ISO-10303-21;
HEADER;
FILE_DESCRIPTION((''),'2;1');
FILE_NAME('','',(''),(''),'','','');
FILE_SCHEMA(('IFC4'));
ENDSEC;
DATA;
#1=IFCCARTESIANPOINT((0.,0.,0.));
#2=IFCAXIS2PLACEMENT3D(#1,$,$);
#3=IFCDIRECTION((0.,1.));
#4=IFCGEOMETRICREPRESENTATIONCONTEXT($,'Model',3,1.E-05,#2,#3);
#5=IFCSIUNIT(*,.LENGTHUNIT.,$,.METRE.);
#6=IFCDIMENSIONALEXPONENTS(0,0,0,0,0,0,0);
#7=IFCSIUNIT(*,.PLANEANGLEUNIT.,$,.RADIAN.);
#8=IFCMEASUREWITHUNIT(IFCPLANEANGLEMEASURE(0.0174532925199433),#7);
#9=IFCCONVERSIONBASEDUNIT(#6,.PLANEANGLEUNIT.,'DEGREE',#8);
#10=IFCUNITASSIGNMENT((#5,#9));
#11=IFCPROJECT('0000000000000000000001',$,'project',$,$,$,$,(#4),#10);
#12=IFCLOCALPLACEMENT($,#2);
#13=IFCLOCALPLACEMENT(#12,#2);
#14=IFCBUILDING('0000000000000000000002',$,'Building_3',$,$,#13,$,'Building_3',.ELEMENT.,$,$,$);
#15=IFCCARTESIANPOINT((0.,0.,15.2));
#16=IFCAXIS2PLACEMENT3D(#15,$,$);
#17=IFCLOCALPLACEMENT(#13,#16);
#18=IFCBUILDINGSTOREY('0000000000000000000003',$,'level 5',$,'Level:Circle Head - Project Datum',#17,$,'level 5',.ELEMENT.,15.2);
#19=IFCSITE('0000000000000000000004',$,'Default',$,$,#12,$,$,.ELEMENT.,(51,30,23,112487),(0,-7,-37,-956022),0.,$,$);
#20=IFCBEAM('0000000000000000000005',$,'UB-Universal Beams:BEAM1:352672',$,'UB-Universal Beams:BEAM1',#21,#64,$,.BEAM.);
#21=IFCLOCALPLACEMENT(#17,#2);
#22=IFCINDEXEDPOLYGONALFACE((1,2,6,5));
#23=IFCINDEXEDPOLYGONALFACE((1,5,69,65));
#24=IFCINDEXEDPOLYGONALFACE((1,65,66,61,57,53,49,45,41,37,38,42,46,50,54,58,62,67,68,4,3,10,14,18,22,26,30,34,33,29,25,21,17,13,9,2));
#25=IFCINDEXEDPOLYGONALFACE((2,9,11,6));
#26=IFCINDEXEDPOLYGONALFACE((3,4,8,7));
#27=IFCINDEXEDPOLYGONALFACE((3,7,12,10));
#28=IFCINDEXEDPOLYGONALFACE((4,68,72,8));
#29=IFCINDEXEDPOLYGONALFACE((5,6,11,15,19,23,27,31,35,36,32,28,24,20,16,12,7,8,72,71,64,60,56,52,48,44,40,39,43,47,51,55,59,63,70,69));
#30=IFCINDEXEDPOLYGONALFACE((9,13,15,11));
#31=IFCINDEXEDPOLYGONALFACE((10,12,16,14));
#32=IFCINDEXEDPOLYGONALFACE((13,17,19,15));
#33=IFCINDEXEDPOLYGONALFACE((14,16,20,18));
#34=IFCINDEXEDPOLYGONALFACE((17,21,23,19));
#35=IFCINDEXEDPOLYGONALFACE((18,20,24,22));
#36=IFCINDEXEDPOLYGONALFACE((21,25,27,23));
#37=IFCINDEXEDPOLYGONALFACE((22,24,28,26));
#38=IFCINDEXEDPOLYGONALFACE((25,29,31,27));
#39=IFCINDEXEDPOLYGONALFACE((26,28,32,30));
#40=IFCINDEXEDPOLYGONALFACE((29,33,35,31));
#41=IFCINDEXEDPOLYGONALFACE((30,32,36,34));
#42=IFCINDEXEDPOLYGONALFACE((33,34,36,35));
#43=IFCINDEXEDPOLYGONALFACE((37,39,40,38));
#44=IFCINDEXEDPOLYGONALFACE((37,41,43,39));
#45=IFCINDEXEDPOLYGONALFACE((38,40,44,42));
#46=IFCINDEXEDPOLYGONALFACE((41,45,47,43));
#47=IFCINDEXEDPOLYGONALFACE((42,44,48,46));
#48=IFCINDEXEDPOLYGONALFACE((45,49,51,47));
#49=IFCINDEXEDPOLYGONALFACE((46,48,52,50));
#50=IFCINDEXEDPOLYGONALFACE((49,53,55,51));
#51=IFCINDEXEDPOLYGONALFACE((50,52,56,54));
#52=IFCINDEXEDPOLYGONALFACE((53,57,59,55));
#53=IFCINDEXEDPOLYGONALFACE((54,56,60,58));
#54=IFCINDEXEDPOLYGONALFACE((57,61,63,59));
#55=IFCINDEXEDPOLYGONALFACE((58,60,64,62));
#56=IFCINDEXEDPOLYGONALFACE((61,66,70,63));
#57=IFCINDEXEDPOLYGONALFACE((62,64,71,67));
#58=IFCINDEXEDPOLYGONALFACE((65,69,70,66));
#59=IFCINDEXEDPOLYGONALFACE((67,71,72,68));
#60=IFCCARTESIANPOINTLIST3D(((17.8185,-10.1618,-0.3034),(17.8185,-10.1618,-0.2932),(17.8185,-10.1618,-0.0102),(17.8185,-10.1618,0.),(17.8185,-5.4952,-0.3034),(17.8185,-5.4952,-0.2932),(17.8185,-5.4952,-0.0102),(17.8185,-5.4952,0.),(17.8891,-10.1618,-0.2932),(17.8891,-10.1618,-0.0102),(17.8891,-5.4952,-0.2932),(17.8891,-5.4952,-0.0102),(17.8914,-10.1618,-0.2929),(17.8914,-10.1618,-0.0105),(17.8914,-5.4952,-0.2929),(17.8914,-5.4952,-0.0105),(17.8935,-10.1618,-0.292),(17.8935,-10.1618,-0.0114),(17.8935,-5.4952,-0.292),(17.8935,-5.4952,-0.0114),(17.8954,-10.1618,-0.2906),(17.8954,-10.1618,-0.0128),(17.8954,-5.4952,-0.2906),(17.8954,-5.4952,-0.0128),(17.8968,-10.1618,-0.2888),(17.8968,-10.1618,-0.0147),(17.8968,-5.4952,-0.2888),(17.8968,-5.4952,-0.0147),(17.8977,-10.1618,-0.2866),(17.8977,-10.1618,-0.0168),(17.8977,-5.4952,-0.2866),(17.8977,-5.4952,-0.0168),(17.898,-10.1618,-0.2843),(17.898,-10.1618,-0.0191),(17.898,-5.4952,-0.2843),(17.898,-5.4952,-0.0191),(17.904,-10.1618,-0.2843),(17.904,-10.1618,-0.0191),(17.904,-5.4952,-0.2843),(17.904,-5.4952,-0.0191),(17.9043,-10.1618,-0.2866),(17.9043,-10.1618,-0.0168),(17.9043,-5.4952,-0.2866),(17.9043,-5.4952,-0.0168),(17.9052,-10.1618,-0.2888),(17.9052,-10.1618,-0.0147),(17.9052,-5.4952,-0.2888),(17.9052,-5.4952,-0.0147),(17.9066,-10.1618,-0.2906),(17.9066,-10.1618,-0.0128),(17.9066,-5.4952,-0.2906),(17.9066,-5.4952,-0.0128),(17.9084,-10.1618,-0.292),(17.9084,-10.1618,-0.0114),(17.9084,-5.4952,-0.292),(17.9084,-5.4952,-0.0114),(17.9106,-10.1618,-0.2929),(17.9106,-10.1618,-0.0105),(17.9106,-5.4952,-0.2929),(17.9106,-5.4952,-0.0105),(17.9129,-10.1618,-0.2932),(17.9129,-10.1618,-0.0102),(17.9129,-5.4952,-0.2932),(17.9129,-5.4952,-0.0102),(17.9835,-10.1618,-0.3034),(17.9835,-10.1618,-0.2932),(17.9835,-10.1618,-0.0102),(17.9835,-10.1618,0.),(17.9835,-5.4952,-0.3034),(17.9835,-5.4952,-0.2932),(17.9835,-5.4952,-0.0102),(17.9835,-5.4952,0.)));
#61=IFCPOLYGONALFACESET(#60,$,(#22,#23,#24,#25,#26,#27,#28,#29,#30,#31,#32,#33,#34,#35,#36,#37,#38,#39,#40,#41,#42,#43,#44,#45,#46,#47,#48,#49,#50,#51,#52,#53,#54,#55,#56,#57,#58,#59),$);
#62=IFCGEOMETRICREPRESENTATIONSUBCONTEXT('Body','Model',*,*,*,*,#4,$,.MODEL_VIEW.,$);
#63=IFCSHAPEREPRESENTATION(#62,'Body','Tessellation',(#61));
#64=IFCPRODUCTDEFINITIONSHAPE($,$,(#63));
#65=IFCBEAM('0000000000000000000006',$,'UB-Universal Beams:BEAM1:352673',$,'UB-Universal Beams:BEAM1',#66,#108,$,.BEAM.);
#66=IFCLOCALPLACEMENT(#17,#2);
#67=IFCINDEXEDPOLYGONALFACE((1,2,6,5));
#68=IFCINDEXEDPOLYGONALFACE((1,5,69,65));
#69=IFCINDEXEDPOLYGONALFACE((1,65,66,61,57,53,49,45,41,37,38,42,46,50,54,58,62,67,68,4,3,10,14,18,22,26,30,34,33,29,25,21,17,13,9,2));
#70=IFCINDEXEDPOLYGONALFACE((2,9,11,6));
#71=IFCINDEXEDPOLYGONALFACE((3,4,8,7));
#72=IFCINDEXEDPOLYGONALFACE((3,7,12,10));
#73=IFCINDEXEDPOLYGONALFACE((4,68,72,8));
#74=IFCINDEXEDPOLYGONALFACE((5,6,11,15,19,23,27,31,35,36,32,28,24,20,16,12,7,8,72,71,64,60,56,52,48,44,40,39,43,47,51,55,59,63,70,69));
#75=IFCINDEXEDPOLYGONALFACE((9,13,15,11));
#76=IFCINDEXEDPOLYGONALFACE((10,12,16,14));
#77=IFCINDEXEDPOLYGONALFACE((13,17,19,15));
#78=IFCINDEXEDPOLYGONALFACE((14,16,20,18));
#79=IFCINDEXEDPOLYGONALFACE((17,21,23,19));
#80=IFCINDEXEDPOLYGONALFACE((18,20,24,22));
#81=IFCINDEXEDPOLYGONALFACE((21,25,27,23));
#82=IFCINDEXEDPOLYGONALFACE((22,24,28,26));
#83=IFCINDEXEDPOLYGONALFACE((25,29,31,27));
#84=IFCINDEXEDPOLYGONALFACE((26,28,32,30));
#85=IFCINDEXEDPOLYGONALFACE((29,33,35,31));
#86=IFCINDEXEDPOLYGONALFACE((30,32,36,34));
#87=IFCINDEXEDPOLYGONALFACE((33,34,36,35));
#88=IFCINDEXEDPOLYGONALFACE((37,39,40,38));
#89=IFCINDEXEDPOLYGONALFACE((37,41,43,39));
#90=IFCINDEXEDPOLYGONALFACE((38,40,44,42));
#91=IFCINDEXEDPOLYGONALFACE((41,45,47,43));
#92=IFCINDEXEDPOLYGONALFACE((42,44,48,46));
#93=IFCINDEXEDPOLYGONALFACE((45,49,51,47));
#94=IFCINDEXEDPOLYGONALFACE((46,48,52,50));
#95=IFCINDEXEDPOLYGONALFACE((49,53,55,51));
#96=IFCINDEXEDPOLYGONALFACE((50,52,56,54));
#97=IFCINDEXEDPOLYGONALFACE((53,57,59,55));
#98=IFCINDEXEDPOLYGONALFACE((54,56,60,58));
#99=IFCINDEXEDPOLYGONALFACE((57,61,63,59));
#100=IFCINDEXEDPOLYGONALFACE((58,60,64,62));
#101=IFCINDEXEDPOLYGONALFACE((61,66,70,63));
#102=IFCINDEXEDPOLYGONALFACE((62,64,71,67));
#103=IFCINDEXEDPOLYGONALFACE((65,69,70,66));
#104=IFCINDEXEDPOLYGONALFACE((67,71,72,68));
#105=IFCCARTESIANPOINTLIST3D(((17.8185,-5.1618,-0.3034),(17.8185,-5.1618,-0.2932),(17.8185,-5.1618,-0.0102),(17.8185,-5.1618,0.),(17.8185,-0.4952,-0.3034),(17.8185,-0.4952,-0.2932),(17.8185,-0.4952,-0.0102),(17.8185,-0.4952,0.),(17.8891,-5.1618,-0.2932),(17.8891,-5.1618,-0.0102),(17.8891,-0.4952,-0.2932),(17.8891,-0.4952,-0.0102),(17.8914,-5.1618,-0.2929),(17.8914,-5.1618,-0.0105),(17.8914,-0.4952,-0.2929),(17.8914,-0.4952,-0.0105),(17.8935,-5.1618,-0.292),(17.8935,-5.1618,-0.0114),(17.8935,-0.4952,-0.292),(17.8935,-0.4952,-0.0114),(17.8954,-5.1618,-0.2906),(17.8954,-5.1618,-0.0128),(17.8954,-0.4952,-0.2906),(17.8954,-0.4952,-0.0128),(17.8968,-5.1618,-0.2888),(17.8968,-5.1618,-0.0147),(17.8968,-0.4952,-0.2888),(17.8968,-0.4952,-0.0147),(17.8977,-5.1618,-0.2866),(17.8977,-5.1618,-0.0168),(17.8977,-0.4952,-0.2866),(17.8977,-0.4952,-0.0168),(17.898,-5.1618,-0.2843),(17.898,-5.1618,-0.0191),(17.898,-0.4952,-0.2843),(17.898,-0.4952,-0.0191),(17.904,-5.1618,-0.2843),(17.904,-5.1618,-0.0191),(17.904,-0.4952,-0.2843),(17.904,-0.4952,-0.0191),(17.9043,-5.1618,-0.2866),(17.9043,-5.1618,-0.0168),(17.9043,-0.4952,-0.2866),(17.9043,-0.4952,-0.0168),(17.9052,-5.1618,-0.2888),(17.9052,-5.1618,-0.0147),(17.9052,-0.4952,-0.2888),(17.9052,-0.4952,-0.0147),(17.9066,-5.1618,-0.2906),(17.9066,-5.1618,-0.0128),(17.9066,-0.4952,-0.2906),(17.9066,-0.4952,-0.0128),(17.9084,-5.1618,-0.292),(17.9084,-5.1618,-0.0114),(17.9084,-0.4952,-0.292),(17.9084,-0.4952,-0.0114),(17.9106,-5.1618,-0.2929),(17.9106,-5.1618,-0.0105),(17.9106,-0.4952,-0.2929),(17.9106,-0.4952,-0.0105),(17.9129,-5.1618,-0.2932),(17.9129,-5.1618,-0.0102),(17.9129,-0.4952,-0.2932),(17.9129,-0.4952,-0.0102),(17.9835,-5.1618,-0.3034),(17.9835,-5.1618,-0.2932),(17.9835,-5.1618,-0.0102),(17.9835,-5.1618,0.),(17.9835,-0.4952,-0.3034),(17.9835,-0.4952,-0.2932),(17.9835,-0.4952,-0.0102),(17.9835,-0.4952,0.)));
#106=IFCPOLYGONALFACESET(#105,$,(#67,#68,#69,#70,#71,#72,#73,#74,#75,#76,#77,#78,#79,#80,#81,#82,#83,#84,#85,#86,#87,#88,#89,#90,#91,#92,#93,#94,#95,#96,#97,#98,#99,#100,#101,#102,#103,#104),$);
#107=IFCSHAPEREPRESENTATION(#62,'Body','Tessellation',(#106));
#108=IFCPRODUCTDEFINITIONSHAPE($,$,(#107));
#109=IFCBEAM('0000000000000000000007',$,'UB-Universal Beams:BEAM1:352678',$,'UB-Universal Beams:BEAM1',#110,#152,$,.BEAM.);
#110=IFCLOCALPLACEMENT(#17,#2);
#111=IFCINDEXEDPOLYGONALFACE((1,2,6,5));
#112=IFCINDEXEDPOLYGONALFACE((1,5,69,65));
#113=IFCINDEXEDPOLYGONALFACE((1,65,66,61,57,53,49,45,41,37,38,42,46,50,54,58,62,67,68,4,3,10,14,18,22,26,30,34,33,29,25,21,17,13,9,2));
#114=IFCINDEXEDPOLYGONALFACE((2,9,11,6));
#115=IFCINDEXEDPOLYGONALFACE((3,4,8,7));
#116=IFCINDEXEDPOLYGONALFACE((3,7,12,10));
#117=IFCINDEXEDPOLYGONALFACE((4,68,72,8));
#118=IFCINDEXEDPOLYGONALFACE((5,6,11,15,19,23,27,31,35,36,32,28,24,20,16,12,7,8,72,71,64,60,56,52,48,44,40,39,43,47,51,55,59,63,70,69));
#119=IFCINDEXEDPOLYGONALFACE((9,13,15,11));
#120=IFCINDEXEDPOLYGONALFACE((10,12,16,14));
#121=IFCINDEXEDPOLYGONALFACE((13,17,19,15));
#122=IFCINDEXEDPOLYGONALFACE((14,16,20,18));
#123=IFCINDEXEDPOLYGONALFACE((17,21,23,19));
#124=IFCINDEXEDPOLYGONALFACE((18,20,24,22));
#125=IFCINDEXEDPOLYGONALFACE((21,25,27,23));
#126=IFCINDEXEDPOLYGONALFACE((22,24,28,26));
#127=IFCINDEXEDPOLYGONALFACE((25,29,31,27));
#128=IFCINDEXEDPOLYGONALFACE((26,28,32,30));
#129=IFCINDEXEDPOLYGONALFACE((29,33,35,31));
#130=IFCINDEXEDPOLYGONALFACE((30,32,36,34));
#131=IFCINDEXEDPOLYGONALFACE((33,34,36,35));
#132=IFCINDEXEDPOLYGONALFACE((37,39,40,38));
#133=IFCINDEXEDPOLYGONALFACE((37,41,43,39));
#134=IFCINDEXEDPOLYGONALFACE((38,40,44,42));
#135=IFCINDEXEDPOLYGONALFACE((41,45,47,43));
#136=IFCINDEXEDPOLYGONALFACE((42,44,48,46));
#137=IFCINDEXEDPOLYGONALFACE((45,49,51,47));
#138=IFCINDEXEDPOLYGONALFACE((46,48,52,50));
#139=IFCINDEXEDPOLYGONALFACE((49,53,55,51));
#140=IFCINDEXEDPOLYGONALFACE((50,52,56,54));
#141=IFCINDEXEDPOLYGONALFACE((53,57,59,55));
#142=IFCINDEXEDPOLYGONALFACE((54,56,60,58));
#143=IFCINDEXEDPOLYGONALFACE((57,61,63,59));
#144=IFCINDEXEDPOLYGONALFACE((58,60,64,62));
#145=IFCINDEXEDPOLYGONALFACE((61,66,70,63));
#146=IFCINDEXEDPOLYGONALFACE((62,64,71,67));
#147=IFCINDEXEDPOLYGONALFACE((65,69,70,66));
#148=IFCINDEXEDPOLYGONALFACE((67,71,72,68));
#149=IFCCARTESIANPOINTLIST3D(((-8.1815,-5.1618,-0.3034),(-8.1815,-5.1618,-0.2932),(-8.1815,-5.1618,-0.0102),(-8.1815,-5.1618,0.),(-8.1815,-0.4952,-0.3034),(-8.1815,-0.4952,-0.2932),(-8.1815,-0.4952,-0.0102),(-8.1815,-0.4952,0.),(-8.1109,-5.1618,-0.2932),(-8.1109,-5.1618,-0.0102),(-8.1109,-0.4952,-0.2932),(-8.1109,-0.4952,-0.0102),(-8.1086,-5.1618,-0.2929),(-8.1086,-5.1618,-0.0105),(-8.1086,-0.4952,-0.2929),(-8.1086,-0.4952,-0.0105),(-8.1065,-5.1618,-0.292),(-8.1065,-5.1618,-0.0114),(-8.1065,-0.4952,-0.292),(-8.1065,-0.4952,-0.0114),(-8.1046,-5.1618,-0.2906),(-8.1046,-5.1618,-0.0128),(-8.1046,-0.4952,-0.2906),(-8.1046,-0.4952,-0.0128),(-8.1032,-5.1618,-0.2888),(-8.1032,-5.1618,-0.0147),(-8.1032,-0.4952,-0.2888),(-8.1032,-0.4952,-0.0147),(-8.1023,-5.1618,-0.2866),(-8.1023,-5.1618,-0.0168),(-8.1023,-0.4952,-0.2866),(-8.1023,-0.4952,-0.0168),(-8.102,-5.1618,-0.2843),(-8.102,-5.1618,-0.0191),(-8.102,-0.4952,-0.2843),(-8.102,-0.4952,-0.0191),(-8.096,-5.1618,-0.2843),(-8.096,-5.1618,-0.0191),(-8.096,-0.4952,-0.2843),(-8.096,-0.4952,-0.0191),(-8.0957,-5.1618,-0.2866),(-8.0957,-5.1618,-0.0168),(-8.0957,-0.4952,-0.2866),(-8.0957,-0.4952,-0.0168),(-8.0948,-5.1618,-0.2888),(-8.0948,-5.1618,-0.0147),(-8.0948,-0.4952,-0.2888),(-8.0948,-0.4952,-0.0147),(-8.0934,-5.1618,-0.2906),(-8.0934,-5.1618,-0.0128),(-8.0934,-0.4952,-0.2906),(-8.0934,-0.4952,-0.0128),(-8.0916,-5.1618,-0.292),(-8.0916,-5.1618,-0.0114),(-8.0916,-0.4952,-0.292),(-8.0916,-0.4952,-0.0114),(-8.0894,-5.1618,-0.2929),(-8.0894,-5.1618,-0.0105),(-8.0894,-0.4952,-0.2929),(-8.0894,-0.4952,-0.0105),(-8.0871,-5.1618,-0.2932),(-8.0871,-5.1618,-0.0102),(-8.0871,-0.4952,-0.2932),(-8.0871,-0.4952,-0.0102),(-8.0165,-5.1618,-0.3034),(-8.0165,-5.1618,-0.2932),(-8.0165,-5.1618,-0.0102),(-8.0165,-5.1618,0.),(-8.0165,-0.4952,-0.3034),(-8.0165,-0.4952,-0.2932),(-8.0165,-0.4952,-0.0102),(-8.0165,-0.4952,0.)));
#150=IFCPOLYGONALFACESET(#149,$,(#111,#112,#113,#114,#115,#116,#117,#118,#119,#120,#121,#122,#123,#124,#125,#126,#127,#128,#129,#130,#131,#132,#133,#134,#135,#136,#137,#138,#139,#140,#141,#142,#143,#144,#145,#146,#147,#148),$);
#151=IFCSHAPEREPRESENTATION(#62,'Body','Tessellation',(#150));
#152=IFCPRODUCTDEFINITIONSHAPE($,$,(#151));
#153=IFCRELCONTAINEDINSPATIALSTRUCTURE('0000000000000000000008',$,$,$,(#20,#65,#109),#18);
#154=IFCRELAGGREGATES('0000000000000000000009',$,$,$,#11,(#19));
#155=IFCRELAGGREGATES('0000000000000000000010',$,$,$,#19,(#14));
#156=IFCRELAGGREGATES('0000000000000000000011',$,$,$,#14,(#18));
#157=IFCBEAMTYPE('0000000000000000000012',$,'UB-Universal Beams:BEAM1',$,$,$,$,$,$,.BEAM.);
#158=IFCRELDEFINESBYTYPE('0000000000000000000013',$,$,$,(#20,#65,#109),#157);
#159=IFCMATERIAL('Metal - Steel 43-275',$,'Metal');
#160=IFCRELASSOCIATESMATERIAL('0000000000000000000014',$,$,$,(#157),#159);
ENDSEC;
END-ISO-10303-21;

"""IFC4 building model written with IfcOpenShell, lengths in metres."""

from ifc_helpers import new_model, entity, si_unit, converted_unit, direction, frame, frame_2d, origin, place, context, subcontext, project, spatial, polyline, circle_curve, parameter, trimmed, segment, composite_curve, outline, extrude, source, transform, mapped, material, material_profile, profile_set, type_object, type_shapes, element, save


model = new_model("IFC4")

# Units and contexts
model_context = context("Model", 3, precision=1e-05, world=origin(), true_north=direction((0.0, 1.0)))
body_context = subcontext(model_context, "Body", "Model", "MODEL_VIEW")
ifc_project = project(units=[si_unit("LENGTHUNIT", "METRE"), converted_unit("PLANEANGLEUNIT", "DEGREE", entity("IfcPlaneAngleMeasure", 0.0174532925199433), si_unit("PLANEANGLEUNIT", "RADIAN"), dimensions=[0, 0, 0, 0, 0, 0, 0])], contexts=[model_context])

# Site, building, storey
site_placement = place(None, origin())
site = spatial("IfcSite", under=ifc_project, at=site_placement, Name="Default", CompositionType="ELEMENT", RefLatitude=(51, 30, 23, 112487), RefLongitude=(0, -7, -37, -956022), RefElevation=0.0)
building_placement = place(site_placement, origin())
building = spatial("IfcBuilding", under=site, at=building_placement, Name="Building_3", LongName="Building_3", CompositionType="ELEMENT")
storey_placement = place(building_placement, frame((0.0, 0.0, 15.2)))
storey = spatial("IfcBuildingStorey", under=building, at=storey_placement, Name="level 5", ObjectType="Level:Circle Head - Project Datum", LongName="level 5", CompositionType="ELEMENT", Elevation=15.2)

# Beams
ifc_material_1 = material(Name="Metal - Steel 43-275", Category="Metal")
ifc_material_profile = material_profile(ifc_material_1, outline(composite_curve([segment(polyline([(-0.0825, -0.1415), (-0.0825, -0.1517)]), True, "CONTINUOUS"), segment(polyline([(-0.0825, -0.1517), (0.0825, -0.1517)]), True, "CONTINUOUS"), segment(polyline([(0.0825, -0.1517), (0.0825, -0.1415)]), True, "CONTINUOUS"), segment(polyline([(0.0825, -0.1415), (0.0119, -0.1415)]), True, "CONTINUOUS"), segment(trimmed(circle_curve(frame_2d((0.0119, -0.1326), x_axis=(1.0, 0.0)), 0.0089), [parameter(180.0)], [parameter(270.0)], True, "PARAMETER"), False, "CONTINUOUS"), segment(polyline([(0.003, -0.1326), (0.003, 0.1326)]), True, "CONTINUOUS"), segment(trimmed(circle_curve(frame_2d((0.0119, 0.1326), x_axis=(1.0, 0.0)), 0.0089), [parameter(90.0)], [parameter(180.0)], True, "PARAMETER"), False, "CONTINUOUS"), segment(polyline([(0.0119, 0.1415), (0.0825, 0.1415)]), True, "CONTINUOUS"), segment(polyline([(0.0825, 0.1415), (0.0825, 0.1517)]), True, "CONTINUOUS"), segment(polyline([(0.0825, 0.1517), (-0.0825, 0.1517)]), True, "CONTINUOUS"), segment(polyline([(-0.0825, 0.1517), (-0.0825, 0.1415)]), True, "CONTINUOUS"), segment(polyline([(-0.0825, 0.1415), (-0.0119, 0.1415)]), True, "CONTINUOUS"), segment(trimmed(circle_curve(frame_2d((-0.0119, 0.1326), x_axis=(1.0, 0.0)), 0.0089), [parameter(360.0)], [parameter(90.0)], True, "PARAMETER"), False, "CONTINUOUS"), segment(polyline([(-0.003, 0.1326), (-0.003, -0.1326)]), True, "CONTINUOUS"), segment(trimmed(circle_curve(frame_2d((-0.0119, -0.1326), x_axis=(1.0, 0.0)), 0.0089), [parameter(270.0)], [parameter(360.0)], True, "PARAMETER"), False, "CONTINUOUS"), segment(polyline([(-0.0119, -0.1415), (-0.0825, -0.1415)]), True, "CONTINUOUS")], self_intersect=False)), Name="BEAM1")
ifc_profile_set = profile_set([ifc_material_profile], Name="BEAM1")
beam_type_1 = type_object("IfcBeamType", Name="UB-Universal Beams:BEAM1", PredefinedType="BEAM", material=ifc_profile_set)
shared_shape_1 = source(origin(), body_context, "Body", "SweptSolid", [
    extrude(outline(composite_curve([segment(polyline([(-0.0825, -0.1415), (-0.0825, -0.1517)]), True, "CONTINUOUS"), segment(polyline([(-0.0825, -0.1517), (0.0825, -0.1517)]), True, "CONTINUOUS"), segment(polyline([(0.0825, -0.1517), (0.0825, -0.1415)]), True, "CONTINUOUS"), segment(polyline([(0.0825, -0.1415), (0.0119, -0.1415)]), True, "CONTINUOUS"), segment(trimmed(circle_curve(frame_2d((0.0119, -0.1326), x_axis=(0.0, -1.0)), 0.0089), [parameter(270.0)], [parameter(360.0)], True, "PARAMETER"), False, "CONTINUOUS"), segment(polyline([(0.003, -0.1326), (0.003, 0.1326)]), True, "CONTINUOUS"), segment(trimmed(circle_curve(frame_2d((0.0119, 0.1326), x_axis=(-1.0, 0.0)), 0.0089), [parameter(270.0)], [parameter(360.0)], True, "PARAMETER"), False, "CONTINUOUS"), segment(polyline([(0.0119, 0.1415), (0.0825, 0.1415)]), True, "CONTINUOUS"), segment(polyline([(0.0825, 0.1415), (0.0825, 0.1517)]), True, "CONTINUOUS"), segment(polyline([(0.0825, 0.1517), (-0.0825, 0.1517)]), True, "CONTINUOUS"), segment(polyline([(-0.0825, 0.1517), (-0.0825, 0.1415)]), True, "CONTINUOUS"), segment(polyline([(-0.0825, 0.1415), (-0.0119, 0.1415)]), True, "CONTINUOUS"), segment(trimmed(circle_curve(frame_2d((-0.0119, 0.1326), x_axis=(0.0, 1.0)), 0.0089), [parameter(270.0)], [parameter(360.0)], True, "PARAMETER"), False, "CONTINUOUS"), segment(polyline([(-0.003, 0.1326), (-0.003, -0.1326)]), True, "CONTINUOUS"), segment(trimmed(circle_curve(frame_2d((-0.0119, -0.1326), x_axis=(1.0, 0.0)), 0.0089), [parameter(270.0)], [parameter(0.0)], True, "PARAMETER"), False, "CONTINUOUS"), segment(polyline([(-0.0119, -0.1415), (-0.0825, -0.1415)]), True, "CONTINUOUS")], self_intersect=False)), frame((-2.3333, 0.0, 0.0), z_axis=(-1.0, 0.0, 0.0), x_axis=(0.0, -1.0, 0.0)), (0.0, 0.0, -1.0), 4.6666),
])
type_shapes(beam_type_1, [shared_shape_1])
for number, where, z_axis, x_axis, name in (
    (1, (17.901, -7.8285, -0.1517), (0.0, 0.0, 1.0), (0.0, -1.0, 0.0), "UB-Universal Beams:BEAM1:352672"),
    (2, (17.901, -2.8285, -0.1517), (0.0, 0.0, 1.0), (0.0, -1.0, 0.0), "UB-Universal Beams:BEAM1:352673"),
    (3, (-8.099, -2.8285, -0.1517), (0.0, 0.0, 1.0), (0.0, 1.0, 0.0), "UB-Universal Beams:BEAM1:352678"),
):
    element("IfcBeam", number, at=place(storey_placement, frame(where, z_axis=z_axis, x_axis=x_axis)), inside=storey, type_object=beam_type_1, Name=name, ObjectType="UB-Universal Beams:BEAM1", PredefinedType="BEAM", context=body_context, shape_type="MappedRepresentation", body=[
        mapped(shared_shape_1, transform((0.0, 0.0, 0.0), scale=1.0)),
    ])

save(model, "model.ifc")
